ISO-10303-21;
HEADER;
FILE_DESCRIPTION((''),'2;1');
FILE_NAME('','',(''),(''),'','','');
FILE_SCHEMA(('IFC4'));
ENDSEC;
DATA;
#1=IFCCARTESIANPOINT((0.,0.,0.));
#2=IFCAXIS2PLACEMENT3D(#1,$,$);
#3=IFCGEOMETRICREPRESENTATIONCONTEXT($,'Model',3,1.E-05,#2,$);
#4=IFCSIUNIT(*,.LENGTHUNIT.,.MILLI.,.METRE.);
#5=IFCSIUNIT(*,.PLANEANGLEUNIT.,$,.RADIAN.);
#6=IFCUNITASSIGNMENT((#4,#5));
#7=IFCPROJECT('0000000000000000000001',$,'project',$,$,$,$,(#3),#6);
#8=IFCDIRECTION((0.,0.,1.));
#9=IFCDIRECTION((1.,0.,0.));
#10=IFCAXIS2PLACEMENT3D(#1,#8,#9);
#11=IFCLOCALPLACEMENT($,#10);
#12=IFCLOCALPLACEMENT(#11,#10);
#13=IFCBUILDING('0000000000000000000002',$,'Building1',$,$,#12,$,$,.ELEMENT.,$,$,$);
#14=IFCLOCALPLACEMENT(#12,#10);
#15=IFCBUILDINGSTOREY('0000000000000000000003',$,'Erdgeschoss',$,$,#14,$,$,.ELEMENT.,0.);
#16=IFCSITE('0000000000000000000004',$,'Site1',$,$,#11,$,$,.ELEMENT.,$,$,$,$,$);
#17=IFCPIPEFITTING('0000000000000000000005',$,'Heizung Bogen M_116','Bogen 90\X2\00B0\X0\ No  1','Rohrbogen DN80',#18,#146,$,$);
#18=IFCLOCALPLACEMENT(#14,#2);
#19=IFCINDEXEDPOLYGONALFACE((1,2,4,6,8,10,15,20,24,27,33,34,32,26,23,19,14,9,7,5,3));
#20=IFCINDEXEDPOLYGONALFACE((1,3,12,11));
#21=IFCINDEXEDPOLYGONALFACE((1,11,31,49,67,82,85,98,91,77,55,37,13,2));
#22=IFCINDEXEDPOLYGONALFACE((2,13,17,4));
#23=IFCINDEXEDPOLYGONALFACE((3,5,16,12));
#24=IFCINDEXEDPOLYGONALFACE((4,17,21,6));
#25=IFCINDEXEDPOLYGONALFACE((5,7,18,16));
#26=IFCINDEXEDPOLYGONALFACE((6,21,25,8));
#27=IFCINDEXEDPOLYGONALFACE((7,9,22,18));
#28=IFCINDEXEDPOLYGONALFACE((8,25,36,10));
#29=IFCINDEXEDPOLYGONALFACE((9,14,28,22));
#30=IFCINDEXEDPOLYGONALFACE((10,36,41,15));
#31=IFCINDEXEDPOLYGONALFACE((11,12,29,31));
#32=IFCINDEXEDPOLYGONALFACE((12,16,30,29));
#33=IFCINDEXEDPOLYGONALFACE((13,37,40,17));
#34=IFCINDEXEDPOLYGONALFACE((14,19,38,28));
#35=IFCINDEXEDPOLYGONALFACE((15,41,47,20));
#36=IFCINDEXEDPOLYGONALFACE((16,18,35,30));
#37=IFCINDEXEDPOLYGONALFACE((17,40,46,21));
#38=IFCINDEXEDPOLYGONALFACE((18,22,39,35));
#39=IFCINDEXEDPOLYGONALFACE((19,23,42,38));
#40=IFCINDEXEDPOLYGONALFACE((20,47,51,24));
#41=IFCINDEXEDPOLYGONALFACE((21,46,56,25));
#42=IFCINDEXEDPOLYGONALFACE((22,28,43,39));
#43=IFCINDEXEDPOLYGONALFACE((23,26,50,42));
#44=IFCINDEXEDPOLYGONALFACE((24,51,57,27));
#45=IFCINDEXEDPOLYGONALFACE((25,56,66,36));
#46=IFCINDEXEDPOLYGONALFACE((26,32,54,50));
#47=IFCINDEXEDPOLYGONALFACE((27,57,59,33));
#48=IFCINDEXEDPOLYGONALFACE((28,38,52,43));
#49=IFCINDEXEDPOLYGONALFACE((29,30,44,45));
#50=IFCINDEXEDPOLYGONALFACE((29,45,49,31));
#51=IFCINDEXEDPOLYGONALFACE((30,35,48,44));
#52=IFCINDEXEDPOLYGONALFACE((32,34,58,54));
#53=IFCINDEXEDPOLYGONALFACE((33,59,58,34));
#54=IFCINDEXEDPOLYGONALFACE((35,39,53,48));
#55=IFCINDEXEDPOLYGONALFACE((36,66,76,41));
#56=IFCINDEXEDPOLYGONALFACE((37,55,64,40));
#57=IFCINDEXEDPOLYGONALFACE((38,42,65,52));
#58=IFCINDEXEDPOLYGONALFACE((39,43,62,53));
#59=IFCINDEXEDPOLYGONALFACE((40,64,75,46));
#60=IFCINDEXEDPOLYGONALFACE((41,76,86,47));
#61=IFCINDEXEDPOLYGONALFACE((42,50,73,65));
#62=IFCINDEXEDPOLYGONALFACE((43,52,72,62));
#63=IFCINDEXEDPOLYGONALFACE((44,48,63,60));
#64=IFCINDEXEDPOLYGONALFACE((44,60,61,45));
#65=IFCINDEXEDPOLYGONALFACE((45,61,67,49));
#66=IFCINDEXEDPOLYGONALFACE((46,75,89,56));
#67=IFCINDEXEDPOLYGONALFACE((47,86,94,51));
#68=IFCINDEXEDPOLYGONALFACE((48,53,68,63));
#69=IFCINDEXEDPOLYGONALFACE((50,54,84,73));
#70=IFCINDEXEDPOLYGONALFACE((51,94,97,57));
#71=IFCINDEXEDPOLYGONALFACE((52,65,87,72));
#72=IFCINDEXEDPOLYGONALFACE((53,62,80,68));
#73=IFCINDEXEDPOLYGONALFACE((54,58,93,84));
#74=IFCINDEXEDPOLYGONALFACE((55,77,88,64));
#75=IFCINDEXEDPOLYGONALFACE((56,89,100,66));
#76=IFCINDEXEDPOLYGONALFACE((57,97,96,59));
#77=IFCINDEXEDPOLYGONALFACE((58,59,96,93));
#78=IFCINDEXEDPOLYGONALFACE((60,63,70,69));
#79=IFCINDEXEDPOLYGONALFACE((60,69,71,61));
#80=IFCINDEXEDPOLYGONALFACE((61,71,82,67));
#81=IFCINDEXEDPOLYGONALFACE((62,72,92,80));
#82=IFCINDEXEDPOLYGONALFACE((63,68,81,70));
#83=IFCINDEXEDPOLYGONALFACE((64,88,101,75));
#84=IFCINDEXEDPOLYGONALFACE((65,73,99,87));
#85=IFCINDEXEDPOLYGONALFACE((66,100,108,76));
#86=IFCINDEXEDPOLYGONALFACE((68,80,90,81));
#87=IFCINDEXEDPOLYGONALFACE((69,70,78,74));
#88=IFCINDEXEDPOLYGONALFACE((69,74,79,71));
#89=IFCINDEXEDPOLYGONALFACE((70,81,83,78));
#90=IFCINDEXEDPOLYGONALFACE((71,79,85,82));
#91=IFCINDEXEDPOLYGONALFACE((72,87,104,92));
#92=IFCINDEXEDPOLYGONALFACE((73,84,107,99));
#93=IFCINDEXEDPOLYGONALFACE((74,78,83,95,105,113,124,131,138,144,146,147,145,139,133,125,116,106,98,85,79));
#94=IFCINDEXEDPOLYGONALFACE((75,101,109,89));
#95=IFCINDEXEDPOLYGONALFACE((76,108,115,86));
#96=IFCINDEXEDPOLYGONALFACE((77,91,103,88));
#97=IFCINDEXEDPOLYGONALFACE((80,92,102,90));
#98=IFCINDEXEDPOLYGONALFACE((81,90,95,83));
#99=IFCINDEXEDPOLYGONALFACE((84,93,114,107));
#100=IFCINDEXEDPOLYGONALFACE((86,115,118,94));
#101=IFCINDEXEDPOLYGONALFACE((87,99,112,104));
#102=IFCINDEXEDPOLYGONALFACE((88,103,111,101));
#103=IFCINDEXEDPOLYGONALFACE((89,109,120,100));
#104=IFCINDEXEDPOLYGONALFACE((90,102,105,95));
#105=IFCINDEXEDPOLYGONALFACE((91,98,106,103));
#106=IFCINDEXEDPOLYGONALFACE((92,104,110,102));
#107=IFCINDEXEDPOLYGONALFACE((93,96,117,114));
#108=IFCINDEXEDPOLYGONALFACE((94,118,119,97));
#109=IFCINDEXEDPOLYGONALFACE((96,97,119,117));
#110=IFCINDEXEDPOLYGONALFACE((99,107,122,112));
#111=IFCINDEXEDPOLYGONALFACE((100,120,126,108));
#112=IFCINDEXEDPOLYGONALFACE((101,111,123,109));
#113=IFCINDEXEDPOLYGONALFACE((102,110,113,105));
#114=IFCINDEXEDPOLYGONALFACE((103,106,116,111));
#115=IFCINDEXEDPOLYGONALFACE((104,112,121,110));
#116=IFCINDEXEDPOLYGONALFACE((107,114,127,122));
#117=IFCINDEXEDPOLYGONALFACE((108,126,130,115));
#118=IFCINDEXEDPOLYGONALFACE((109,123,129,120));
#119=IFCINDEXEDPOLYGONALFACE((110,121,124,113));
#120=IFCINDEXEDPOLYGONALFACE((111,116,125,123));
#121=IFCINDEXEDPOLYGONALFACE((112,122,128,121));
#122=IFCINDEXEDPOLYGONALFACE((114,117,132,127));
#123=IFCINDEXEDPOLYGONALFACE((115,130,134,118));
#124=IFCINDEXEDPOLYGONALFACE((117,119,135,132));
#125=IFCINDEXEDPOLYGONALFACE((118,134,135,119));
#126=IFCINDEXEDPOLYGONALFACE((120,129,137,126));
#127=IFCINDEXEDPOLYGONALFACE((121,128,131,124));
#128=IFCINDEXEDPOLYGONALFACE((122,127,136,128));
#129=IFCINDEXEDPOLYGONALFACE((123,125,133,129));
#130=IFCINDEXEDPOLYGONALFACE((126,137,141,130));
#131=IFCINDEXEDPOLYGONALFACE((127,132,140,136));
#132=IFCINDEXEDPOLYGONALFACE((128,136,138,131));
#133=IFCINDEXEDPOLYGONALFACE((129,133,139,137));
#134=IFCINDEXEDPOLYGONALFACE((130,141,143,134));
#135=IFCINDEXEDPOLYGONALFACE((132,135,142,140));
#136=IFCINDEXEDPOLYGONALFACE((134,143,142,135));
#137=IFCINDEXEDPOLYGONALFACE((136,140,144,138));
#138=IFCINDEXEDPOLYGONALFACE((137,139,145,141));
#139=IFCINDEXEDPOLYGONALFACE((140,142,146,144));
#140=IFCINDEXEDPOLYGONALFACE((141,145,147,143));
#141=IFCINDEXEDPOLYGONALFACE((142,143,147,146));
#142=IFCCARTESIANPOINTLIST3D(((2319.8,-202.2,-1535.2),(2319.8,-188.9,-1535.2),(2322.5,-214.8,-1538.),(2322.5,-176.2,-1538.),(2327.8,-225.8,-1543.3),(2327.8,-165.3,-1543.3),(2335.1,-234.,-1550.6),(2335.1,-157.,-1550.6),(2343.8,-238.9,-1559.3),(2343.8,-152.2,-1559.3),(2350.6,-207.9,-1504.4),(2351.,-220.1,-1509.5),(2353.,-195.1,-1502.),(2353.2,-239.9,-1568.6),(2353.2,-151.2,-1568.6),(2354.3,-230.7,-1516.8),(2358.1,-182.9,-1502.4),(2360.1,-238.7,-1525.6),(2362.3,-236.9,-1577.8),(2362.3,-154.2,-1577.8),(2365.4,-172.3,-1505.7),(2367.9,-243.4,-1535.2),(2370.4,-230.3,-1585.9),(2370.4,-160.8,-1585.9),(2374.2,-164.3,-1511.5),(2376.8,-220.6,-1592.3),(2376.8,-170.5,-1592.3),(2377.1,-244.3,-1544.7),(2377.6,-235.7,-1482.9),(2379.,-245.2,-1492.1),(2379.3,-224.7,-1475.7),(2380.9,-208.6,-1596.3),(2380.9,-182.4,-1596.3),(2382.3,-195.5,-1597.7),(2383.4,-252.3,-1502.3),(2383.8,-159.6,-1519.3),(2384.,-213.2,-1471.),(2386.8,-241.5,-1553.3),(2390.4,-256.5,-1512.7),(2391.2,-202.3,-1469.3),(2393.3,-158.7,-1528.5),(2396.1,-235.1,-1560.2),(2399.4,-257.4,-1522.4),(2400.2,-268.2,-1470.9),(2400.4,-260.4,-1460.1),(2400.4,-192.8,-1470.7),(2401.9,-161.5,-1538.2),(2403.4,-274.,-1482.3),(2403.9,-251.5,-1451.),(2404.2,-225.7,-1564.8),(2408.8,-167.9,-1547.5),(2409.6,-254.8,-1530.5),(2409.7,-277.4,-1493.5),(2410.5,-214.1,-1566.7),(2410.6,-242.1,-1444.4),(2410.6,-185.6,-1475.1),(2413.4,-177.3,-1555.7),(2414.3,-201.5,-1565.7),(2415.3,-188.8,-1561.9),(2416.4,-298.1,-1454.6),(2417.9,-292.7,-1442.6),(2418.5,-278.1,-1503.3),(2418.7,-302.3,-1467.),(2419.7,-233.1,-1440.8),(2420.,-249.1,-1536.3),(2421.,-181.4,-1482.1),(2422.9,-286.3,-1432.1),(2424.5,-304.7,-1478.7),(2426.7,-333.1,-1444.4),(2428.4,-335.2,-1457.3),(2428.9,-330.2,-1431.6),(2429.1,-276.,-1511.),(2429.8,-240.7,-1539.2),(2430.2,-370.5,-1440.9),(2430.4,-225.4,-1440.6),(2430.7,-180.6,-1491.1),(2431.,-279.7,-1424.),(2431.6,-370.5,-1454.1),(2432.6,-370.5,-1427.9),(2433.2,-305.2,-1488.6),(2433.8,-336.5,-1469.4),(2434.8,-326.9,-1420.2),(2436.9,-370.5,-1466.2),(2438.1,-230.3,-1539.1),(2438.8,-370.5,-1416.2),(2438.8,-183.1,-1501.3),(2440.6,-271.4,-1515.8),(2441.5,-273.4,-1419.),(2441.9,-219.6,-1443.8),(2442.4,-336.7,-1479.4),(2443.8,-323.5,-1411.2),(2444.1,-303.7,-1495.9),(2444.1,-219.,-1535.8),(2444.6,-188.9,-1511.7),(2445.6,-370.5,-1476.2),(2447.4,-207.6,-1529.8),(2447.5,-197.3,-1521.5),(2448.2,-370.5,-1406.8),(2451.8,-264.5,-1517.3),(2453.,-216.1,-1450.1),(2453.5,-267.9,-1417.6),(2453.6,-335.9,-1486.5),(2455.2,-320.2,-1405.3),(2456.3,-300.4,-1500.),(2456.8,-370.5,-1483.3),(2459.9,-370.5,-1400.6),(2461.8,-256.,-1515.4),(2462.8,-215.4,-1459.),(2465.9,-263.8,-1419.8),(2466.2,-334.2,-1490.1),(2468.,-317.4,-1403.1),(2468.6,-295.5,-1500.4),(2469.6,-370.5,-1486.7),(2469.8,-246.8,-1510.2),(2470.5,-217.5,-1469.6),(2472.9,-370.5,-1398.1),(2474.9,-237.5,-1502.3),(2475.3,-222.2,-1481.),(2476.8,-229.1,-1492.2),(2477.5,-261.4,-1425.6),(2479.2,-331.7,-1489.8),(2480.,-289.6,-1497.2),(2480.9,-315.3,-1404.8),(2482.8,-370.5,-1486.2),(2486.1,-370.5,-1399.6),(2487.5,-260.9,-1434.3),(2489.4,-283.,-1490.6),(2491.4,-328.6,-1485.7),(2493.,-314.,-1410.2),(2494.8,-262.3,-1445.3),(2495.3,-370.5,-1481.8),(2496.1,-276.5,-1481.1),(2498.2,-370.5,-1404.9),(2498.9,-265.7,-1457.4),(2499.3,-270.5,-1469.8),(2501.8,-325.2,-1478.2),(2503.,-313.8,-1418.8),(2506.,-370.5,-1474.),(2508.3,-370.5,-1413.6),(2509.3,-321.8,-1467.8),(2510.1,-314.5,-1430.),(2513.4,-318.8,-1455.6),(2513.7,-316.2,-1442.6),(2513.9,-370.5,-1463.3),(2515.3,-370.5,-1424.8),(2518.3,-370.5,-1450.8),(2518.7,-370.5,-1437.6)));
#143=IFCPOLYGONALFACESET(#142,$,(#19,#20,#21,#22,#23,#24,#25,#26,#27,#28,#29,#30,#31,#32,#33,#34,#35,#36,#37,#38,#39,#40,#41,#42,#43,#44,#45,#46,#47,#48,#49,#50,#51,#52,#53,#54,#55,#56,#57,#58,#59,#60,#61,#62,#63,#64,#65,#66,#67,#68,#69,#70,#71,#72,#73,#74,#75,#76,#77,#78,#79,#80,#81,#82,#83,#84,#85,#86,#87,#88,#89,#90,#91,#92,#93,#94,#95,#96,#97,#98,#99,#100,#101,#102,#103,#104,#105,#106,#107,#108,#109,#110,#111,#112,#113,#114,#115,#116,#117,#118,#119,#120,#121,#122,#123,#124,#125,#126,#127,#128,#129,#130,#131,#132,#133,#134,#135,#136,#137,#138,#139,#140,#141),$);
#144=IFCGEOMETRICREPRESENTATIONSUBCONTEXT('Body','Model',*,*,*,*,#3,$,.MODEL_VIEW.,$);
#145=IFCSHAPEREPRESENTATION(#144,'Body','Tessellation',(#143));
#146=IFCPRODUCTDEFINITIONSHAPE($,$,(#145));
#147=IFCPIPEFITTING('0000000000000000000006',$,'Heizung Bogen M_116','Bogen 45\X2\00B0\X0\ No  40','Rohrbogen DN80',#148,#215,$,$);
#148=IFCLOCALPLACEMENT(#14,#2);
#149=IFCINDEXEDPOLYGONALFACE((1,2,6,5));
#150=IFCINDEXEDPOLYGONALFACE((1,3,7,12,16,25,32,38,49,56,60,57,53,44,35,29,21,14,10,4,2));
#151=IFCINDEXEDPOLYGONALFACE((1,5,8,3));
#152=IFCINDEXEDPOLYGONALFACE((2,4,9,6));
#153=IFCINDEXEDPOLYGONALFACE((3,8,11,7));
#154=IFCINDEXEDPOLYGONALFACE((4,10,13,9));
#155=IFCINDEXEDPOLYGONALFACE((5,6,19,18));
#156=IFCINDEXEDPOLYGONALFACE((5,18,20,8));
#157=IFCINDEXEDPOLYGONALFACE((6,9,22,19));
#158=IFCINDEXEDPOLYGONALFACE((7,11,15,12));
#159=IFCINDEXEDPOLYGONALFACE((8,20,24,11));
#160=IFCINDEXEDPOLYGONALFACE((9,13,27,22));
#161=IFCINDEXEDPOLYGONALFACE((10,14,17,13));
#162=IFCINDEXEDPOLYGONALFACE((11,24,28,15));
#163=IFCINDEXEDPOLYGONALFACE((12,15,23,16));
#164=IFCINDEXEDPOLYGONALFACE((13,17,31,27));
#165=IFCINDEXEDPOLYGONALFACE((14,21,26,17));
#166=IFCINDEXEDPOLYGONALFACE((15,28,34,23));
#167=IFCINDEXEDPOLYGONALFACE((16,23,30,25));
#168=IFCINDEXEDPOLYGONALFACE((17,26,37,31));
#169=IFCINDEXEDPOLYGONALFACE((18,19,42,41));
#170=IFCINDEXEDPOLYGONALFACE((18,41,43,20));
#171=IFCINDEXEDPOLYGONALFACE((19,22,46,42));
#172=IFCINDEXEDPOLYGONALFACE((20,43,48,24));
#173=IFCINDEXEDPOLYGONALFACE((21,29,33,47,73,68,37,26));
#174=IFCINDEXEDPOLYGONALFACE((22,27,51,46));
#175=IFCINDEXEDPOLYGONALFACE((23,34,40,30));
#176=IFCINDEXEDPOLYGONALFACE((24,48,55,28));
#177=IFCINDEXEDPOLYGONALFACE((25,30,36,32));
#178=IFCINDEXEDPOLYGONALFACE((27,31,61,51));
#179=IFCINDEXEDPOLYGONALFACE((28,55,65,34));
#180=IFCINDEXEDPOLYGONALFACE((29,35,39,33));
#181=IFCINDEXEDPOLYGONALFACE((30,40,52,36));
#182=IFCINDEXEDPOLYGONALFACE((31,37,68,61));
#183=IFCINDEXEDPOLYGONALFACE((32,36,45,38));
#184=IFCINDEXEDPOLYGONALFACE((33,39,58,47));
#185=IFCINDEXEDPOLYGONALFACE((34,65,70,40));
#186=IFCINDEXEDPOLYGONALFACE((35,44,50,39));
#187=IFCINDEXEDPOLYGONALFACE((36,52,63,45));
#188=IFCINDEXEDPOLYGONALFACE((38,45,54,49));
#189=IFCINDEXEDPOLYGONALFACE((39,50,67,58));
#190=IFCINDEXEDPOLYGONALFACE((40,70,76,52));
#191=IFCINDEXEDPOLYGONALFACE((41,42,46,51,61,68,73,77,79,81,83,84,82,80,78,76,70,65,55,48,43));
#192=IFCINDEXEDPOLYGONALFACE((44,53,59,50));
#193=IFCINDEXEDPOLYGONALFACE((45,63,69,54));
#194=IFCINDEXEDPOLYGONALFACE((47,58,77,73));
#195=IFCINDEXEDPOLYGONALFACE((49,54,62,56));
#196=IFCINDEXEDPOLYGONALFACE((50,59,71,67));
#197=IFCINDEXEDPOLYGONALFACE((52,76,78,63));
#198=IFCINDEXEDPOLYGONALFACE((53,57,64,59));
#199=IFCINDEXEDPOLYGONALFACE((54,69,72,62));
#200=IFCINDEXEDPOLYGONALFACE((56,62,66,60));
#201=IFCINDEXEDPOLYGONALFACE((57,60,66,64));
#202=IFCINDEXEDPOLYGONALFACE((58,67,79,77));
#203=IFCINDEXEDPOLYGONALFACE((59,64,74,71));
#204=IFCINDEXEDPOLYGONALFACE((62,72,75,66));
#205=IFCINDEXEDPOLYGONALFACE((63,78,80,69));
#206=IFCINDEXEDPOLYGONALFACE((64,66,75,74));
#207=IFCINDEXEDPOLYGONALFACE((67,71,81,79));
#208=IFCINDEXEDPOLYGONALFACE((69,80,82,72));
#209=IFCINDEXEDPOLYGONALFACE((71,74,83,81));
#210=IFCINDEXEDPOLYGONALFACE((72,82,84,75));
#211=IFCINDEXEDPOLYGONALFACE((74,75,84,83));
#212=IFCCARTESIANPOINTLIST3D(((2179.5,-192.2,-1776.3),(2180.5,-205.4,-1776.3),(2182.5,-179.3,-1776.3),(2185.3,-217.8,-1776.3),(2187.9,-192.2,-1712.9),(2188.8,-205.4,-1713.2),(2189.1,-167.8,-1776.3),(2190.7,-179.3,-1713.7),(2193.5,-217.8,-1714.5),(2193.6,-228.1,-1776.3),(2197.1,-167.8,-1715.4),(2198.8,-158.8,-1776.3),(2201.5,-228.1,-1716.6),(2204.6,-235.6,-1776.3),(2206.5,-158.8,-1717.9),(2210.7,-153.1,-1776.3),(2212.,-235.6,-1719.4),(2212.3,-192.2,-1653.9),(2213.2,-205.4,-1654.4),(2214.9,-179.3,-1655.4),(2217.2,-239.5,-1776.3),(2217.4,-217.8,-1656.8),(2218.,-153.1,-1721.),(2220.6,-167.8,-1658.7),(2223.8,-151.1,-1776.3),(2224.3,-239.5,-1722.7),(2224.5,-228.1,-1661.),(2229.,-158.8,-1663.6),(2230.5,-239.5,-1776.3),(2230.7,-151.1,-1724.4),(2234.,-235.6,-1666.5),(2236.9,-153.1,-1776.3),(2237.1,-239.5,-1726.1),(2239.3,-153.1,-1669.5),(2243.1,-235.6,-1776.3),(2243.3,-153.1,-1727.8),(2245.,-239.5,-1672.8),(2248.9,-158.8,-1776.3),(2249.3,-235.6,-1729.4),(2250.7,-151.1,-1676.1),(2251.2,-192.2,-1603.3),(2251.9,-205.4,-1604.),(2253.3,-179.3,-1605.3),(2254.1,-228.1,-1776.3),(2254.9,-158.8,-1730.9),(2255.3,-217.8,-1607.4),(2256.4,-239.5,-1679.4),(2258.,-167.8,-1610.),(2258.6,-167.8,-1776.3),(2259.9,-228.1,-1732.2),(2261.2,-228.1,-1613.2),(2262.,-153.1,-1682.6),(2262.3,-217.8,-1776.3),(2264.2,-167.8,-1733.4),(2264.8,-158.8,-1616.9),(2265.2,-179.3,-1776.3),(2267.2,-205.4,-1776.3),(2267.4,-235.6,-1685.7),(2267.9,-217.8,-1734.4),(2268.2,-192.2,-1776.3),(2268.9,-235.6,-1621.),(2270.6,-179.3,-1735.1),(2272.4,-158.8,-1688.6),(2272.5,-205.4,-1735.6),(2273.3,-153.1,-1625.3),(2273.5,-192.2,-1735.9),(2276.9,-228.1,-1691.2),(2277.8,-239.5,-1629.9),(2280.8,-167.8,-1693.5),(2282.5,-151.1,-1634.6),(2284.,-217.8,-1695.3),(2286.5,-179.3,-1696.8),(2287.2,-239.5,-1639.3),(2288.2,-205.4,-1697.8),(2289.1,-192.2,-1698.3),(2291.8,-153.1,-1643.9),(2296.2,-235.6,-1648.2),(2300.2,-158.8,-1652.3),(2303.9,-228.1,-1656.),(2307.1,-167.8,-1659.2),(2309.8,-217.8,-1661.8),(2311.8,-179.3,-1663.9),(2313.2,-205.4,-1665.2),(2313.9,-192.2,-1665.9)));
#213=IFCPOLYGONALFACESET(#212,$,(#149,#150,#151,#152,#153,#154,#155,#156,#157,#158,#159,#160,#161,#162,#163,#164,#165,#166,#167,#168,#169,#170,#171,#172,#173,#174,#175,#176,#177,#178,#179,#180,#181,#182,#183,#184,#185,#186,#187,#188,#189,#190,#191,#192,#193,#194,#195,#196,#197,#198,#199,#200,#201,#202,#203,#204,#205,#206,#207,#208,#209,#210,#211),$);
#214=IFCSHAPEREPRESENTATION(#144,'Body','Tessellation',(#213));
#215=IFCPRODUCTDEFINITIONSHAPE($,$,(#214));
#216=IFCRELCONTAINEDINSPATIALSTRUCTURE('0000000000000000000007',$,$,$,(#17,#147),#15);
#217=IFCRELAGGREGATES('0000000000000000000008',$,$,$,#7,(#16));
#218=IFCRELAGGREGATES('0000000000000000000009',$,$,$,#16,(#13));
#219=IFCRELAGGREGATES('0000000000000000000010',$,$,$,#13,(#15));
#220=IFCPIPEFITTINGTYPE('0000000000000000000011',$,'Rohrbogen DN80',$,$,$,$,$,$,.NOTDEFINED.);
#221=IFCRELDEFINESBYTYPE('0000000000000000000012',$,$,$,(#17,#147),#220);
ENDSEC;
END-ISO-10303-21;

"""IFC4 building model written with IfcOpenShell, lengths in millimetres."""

from ifc_helpers import new_model, entity, si_unit, frame, origin, origin_with_axes, place, context, subcontext, project, spatial, source, transform, mapped, type_object, element, save


model = new_model("IFC4")

# Units and contexts
model_context = context("Model", 3, precision=1e-05, world=origin())
body_context = subcontext(model_context, "Body", "Model", "MODEL_VIEW")
ifc_project = project(units=[si_unit("LENGTHUNIT", "METRE", prefix="MILLI"), si_unit("PLANEANGLEUNIT", "RADIAN")], contexts=[model_context])

# Site, building, storey
site_placement = place(None, origin_with_axes())
site = spatial("IfcSite", under=ifc_project, at=site_placement, Name="Site1", CompositionType="ELEMENT")
building_placement = place(site_placement, origin_with_axes())
building = spatial("IfcBuilding", under=site, at=building_placement, Name="Building1", CompositionType="ELEMENT")
storey_placement = place(building_placement, origin_with_axes())
storey = spatial("IfcBuildingStorey", under=building, at=storey_placement, Name="Erdgeschoss", CompositionType="ELEMENT", Elevation=0.0)

# Pipe fittings
pipe_fitting_type_1 = type_object("IfcPipeFittingType", Name="Rohrbogen DN80", PredefinedType="NOTDEFINED")
shared_shape_1 = source(origin_with_axes(), body_context, "Body", "SolidModel", [
    entity("IfcRevolvedAreaSolid", entity("IfcCircleProfileDef", "AREA", None, entity("IfcAxis2Placement2D", entity("IfcCartesianPoint", [0.0, 0.0]), entity("IfcDirection", [1.0, 0.0])), 44.5), entity("IfcAxis2Placement3D", entity("IfcCartesianPoint", [-109.7, 46.2, -46.2]), entity("IfcDirection", [1.0, 0.0, 0.0]), entity("IfcDirection", [0.0, 0.707107, 0.707107])), entity("IfcAxis1Placement", entity("IfcCartesianPoint", [0.0, 175.0, 0.0]), entity("IfcDirection", [-1.0, 0.0, 0.0])), 1.570796),
])
pipe_fitting_1_placement = place(storey_placement, frame((2428.4, -260.8, -1488.7), z_axis=(0.0, 0.0, 1.0), x_axis=(1.0, 0.0, 0.0)))
element("IfcPipeFitting", 1, at=pipe_fitting_1_placement, inside=storey, type_object=pipe_fitting_type_1, Name="Heizung Bogen M_116", Description="Bogen 90° No  1", ObjectType="Rohrbogen DN80", context=body_context, shape_type="MappedRepresentation", body=[
    mapped(shared_shape_1, transform((0.0, 0.0, 0.0), x_axis=(0.0, 1.0, 0.0), y_axis=(1.0, 0.0, 0.0), z_axis=(0.0, 0.0, -1.0), scale=1.0)),
])
shared_shape_2 = source(origin_with_axes(), body_context, "Body", "SolidModel", [
    entity("IfcRevolvedAreaSolid", entity("IfcCircleProfileDef", "AREA", None, entity("IfcAxis2Placement2D", entity("IfcCartesianPoint", [0.0, 0.0]), entity("IfcDirection", [1.0, 0.0])), 44.5), entity("IfcAxis2Placement3D", entity("IfcCartesianPoint", [79.5, 22.8, 0.0]), entity("IfcDirection", [-1.0, 0.0, 0.0]), entity("IfcDirection", [0.0, 0.0, -1.0])), entity("IfcAxis1Placement", entity("IfcCartesianPoint", [0.0, 200.4, 0.0]), entity("IfcDirection", [-1.0, 0.0, 0.0])), 0.785398),
])
pipe_fitting_2_placement = place(storey_placement, frame((2242.5, -195.5, -1706.9), z_axis=(0.0, 0.0, 1.0), x_axis=(1.0, 0.0, 0.0)))
element("IfcPipeFitting", 2, at=pipe_fitting_2_placement, inside=storey, type_object=pipe_fitting_type_1, Name="Heizung Bogen M_116", Description="Bogen 45° No  40", ObjectType="Rohrbogen DN80", context=body_context, shape_type="MappedRepresentation", body=[
    mapped(shared_shape_2, transform((0.0, 0.0, 0.0), x_axis=(0.707107, 0.0, 0.707107), y_axis=(-0.707107, 0.0, 0.707107), z_axis=(0.0, -1.0, 0.0), scale=1.0)),
])

save(model, "model.ifc")
